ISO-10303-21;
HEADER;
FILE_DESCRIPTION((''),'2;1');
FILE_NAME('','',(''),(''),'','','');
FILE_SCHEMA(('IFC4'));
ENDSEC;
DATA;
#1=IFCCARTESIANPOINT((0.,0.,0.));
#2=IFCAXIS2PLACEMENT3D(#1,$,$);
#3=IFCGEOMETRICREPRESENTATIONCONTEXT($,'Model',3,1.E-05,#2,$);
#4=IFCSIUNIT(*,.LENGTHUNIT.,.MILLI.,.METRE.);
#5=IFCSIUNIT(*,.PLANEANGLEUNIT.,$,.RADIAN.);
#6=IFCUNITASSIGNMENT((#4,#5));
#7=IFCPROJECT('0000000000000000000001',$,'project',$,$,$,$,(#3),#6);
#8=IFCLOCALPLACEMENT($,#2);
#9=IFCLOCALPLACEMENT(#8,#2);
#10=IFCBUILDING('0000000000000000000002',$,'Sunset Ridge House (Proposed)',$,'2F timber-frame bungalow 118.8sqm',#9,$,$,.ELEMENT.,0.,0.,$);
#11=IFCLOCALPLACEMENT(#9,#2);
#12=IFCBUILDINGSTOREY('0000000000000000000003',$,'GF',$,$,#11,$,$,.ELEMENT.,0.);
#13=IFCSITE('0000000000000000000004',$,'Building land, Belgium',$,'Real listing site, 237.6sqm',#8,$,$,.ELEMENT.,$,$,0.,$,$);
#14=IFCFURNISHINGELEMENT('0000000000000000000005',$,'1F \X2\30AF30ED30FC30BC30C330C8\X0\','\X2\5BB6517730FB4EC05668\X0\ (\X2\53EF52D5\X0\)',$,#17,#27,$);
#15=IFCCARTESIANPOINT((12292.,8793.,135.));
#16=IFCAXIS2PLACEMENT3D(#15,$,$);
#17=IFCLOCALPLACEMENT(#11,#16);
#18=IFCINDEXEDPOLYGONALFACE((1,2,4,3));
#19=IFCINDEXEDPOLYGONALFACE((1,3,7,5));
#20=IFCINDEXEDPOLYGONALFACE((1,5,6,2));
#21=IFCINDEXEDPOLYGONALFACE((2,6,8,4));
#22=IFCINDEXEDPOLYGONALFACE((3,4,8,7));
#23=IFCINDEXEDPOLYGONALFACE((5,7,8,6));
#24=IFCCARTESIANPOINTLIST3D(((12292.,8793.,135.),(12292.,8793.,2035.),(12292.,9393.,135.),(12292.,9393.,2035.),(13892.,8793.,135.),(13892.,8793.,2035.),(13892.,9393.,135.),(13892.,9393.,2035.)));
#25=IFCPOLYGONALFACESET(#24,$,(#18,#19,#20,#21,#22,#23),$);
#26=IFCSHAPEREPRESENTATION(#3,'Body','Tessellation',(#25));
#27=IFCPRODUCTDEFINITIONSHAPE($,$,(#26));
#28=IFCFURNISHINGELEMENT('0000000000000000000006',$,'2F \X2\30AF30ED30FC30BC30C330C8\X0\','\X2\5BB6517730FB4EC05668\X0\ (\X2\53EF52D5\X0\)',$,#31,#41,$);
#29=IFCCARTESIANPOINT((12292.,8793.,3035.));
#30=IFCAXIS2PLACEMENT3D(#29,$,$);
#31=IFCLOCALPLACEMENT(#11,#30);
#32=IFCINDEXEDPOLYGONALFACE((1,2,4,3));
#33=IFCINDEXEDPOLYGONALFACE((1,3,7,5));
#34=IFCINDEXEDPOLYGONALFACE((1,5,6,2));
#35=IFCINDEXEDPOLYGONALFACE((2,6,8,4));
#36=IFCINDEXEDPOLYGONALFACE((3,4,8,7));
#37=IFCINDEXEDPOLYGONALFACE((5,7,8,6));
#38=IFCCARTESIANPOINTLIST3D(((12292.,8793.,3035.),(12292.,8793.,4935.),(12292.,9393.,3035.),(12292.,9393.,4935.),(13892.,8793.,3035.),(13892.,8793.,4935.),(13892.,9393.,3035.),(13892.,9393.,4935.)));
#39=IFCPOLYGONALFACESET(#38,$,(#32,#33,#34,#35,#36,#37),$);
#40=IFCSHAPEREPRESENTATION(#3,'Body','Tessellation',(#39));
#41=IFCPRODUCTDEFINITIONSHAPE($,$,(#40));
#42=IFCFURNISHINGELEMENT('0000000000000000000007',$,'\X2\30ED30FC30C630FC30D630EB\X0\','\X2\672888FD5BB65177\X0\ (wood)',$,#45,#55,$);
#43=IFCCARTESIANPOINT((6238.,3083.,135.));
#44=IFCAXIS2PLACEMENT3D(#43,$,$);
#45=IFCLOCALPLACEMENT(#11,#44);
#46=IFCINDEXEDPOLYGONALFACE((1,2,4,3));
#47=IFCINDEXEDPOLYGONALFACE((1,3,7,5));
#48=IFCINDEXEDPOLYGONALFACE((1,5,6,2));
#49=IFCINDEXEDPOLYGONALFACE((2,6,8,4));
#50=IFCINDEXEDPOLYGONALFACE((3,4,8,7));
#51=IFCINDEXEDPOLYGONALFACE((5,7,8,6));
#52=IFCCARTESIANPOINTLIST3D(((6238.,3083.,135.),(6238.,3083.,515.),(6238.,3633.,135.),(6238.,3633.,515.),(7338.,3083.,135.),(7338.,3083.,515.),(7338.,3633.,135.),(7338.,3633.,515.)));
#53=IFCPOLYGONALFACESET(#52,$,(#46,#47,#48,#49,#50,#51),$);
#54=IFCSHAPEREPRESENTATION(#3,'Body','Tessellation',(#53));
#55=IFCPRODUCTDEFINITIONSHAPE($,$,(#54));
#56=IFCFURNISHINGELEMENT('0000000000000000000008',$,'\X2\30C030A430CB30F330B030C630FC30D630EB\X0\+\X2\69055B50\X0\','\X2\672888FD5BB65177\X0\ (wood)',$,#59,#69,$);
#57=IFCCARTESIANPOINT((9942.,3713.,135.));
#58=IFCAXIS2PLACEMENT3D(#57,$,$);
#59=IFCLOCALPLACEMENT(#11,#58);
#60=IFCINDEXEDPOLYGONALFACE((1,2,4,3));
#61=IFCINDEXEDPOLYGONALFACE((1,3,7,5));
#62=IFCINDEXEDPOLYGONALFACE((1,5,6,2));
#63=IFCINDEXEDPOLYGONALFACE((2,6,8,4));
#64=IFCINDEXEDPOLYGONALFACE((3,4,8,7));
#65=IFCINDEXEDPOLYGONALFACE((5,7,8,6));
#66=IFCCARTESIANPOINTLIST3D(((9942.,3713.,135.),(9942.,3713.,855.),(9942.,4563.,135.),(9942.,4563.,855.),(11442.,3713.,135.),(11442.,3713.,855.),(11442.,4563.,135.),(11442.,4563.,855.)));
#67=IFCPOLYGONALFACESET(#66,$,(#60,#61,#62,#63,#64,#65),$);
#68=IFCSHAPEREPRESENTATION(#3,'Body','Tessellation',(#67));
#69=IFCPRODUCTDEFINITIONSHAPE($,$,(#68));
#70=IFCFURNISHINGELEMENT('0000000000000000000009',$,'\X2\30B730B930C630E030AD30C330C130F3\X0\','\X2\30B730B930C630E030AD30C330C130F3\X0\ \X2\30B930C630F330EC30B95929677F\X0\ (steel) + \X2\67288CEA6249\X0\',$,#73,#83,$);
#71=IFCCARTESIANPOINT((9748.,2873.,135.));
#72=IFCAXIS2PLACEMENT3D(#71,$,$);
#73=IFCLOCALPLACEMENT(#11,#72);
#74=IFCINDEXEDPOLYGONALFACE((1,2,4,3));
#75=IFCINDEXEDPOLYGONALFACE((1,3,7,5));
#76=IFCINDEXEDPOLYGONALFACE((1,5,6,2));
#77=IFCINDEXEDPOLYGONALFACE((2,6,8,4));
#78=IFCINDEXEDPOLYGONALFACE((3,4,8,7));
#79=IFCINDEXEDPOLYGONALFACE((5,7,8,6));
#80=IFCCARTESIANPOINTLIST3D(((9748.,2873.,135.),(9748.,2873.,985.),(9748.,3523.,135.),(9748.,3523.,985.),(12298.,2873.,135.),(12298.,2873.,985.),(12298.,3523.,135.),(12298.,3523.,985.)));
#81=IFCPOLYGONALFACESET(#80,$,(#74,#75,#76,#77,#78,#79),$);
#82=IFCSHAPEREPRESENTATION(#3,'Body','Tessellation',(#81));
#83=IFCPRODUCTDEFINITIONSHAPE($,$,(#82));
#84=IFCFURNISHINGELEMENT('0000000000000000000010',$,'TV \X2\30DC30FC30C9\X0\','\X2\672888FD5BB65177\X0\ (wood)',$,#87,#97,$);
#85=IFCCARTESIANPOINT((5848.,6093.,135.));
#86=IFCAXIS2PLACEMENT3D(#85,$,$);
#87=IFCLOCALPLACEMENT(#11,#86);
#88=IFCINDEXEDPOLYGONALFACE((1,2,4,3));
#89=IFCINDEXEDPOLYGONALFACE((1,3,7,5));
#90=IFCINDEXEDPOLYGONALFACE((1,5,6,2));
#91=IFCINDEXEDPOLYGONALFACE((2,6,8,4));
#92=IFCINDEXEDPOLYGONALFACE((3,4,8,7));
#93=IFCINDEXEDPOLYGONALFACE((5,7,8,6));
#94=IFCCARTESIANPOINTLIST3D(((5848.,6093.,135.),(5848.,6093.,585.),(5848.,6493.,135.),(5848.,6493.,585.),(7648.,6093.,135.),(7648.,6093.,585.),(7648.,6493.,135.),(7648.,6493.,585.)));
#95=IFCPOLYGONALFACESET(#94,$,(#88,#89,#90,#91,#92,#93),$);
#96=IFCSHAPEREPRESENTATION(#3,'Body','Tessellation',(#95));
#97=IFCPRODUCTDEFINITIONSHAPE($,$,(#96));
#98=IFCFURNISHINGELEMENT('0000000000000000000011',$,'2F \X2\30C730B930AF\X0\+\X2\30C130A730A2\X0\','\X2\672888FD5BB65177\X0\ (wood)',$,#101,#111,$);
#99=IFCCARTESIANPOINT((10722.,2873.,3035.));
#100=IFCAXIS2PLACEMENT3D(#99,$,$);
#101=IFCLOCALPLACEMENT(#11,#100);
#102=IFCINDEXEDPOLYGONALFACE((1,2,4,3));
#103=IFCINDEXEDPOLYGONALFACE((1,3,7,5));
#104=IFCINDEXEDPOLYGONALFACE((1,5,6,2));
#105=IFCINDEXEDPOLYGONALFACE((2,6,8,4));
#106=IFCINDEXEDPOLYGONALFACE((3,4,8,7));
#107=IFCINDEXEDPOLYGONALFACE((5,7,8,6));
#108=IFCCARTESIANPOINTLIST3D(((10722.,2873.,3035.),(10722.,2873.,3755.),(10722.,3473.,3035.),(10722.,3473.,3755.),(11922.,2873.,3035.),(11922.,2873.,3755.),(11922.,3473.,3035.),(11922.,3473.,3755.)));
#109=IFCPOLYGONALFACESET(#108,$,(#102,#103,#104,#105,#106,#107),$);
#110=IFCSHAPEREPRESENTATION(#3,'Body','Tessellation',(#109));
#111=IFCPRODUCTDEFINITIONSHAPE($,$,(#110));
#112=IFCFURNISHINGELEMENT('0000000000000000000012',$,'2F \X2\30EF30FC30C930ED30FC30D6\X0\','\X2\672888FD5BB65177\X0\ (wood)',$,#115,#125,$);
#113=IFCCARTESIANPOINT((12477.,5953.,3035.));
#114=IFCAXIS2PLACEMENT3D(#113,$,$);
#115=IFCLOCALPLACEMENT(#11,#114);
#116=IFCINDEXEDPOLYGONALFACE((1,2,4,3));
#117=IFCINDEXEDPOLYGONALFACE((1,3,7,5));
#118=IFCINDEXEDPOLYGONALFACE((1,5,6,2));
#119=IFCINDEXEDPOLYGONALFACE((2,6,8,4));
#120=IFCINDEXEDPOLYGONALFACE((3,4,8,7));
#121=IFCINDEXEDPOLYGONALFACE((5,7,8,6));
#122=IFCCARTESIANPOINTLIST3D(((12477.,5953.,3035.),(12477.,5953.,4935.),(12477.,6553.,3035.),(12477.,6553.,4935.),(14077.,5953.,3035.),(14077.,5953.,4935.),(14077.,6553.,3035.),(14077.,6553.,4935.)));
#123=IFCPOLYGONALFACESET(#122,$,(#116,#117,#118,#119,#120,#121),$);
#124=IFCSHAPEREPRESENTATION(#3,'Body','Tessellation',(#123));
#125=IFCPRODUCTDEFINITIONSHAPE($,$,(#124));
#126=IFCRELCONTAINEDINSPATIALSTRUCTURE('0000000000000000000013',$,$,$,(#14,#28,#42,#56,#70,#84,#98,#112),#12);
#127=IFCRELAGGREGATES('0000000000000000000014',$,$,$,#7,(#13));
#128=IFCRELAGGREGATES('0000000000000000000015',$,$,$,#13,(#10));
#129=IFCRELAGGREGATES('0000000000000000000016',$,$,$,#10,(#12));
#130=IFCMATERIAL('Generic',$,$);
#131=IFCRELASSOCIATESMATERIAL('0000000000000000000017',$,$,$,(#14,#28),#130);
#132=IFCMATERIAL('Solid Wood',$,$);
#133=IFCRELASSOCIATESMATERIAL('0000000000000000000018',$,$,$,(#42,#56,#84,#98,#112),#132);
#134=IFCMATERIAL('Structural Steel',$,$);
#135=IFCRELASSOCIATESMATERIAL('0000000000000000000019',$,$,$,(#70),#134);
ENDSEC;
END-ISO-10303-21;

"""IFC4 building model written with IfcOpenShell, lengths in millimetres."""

from ifc_helpers import new_model, si_unit, frame, frame_2d, origin, place, context, project, spatial, rectangle, extrude, material, element, save


model = new_model("IFC4")

# Units and contexts
model_context = context("Model", 3, precision=1e-05, world=origin())
ifc_project = project(units=[si_unit("LENGTHUNIT", "METRE", prefix="MILLI"), si_unit("PLANEANGLEUNIT", "RADIAN")], contexts=[model_context])

# Site, building, storey
site_placement = place(None, origin())
site = spatial("IfcSite", under=ifc_project, at=site_placement, Name="Building land, Belgium", ObjectType="Real listing site, 237.6sqm", CompositionType="ELEMENT", RefElevation=0.0)
building_placement = place(site_placement, origin())
building = spatial("IfcBuilding", under=site, at=building_placement, Name="Sunset Ridge House (Proposed)", ObjectType="2F timber-frame bungalow 118.8sqm", CompositionType="ELEMENT", ElevationOfRefHeight=0.0, ElevationOfTerrain=0.0)
storey_placement = place(building_placement, origin())
storey = spatial("IfcBuildingStorey", under=building, at=storey_placement, Name="GF", CompositionType="ELEMENT", Elevation=0.0)

# Shared definitions
ifc_material_1 = material(Name="Solid Wood")

# Shared definitions
ifc_material_2 = material(Name="Generic")

# Furnishing elements
furnishing_1_placement = place(storey_placement, frame((12292.0, 8793.0, 135.0)))
element("IfcFurnishingElement", 1, at=furnishing_1_placement, inside=storey, material=ifc_material_2, Name="1F クローゼット", Description="家具・什器 (可動)", context=model_context, shape_type="SweptSolid", body=[
    extrude(rectangle(XDim=1600.0, YDim=600.0, at=frame_2d((800.0, 300.0))), frame((12292.0, 8793.0, 135.0)), (0.0, 0.0, 1.0), 1900.0),
])
furnishing_2_placement = place(storey_placement, frame((12292.0, 8793.0, 3035.0)))
element("IfcFurnishingElement", 2, at=furnishing_2_placement, inside=storey, material=ifc_material_2, Name="2F クローゼット", Description="家具・什器 (可動)", context=model_context, shape_type="SweptSolid", body=[
    extrude(rectangle(XDim=1600.0, YDim=600.0, at=frame_2d((800.0, 300.0))), frame((12292.0, 8793.0, 3035.0)), (0.0, 0.0, 1.0), 1900.0),
])
furnishing_3_placement = place(storey_placement, frame((6238.0, 3083.0, 135.0)))
element("IfcFurnishingElement", 3, at=furnishing_3_placement, inside=storey, material=ifc_material_1, Name="ローテーブル", Description="木製家具 (wood)", context=model_context, shape_type="SweptSolid", body=[
    extrude(rectangle(XDim=1100.0, YDim=550.0, at=frame_2d((550.0, 275.0))), frame((6238.0, 3083.0, 135.0)), (0.0, 0.0, 1.0), 380.0),
])
furnishing_4_placement = place(storey_placement, frame((9942.0, 3713.0, 135.0)))
element("IfcFurnishingElement", 4, at=furnishing_4_placement, inside=storey, material=ifc_material_1, Name="ダイニングテーブル+椅子", Description="木製家具 (wood)", context=model_context, shape_type="SweptSolid", body=[
    extrude(rectangle(XDim=1500.0, YDim=850.0, at=frame_2d((750.0, 425.0))), frame((9942.0, 3713.0, 135.0)), (0.0, 0.0, 1.0), 720.0),
])
ifc_material_3 = material(Name="Structural Steel")
furnishing_5_placement = place(storey_placement, frame((9748.0, 2873.0, 135.0)))
element("IfcFurnishingElement", 5, at=furnishing_5_placement, inside=storey, material=ifc_material_3, Name="システムキッチン", Description="システムキッチン ステンレス天板 (steel) + 木質扉", context=model_context, shape_type="SweptSolid", body=[
    extrude(rectangle(XDim=2550.0, YDim=650.0, at=frame_2d((1275.0, 325.0))), frame((9748.0, 2873.0, 135.0)), (0.0, 0.0, 1.0), 850.0),
])
furnishing_6_placement = place(storey_placement, frame((5848.0, 6093.0, 135.0)))
element("IfcFurnishingElement", 6, at=furnishing_6_placement, inside=storey, material=ifc_material_1, Name="TV ボード", Description="木製家具 (wood)", context=model_context, shape_type="SweptSolid", body=[
    extrude(rectangle(XDim=1800.0, YDim=400.0, at=frame_2d((900.0, 200.0))), frame((5848.0, 6093.0, 135.0)), (0.0, 0.0, 1.0), 450.0),
])
furnishing_7_placement = place(storey_placement, frame((10722.0, 2873.0, 3035.0)))
element("IfcFurnishingElement", 7, at=furnishing_7_placement, inside=storey, material=ifc_material_1, Name="2F デスク+チェア", Description="木製家具 (wood)", context=model_context, shape_type="SweptSolid", body=[
    extrude(rectangle(XDim=1200.0, YDim=600.0, at=frame_2d((600.0, 300.0))), frame((10722.0, 2873.0, 3035.0)), (0.0, 0.0, 1.0), 720.0),
])
furnishing_8_placement = place(storey_placement, frame((12477.0, 5953.0, 3035.0)))
element("IfcFurnishingElement", 8, at=furnishing_8_placement, inside=storey, material=ifc_material_1, Name="2F ワードローブ", Description="木製家具 (wood)", context=model_context, shape_type="SweptSolid", body=[
    extrude(rectangle(XDim=1600.0, YDim=600.0, at=frame_2d((800.0, 300.0))), frame((12477.0, 5953.0, 3035.0)), (0.0, 0.0, 1.0), 1900.0),
])

save(model, "model.ifc")
